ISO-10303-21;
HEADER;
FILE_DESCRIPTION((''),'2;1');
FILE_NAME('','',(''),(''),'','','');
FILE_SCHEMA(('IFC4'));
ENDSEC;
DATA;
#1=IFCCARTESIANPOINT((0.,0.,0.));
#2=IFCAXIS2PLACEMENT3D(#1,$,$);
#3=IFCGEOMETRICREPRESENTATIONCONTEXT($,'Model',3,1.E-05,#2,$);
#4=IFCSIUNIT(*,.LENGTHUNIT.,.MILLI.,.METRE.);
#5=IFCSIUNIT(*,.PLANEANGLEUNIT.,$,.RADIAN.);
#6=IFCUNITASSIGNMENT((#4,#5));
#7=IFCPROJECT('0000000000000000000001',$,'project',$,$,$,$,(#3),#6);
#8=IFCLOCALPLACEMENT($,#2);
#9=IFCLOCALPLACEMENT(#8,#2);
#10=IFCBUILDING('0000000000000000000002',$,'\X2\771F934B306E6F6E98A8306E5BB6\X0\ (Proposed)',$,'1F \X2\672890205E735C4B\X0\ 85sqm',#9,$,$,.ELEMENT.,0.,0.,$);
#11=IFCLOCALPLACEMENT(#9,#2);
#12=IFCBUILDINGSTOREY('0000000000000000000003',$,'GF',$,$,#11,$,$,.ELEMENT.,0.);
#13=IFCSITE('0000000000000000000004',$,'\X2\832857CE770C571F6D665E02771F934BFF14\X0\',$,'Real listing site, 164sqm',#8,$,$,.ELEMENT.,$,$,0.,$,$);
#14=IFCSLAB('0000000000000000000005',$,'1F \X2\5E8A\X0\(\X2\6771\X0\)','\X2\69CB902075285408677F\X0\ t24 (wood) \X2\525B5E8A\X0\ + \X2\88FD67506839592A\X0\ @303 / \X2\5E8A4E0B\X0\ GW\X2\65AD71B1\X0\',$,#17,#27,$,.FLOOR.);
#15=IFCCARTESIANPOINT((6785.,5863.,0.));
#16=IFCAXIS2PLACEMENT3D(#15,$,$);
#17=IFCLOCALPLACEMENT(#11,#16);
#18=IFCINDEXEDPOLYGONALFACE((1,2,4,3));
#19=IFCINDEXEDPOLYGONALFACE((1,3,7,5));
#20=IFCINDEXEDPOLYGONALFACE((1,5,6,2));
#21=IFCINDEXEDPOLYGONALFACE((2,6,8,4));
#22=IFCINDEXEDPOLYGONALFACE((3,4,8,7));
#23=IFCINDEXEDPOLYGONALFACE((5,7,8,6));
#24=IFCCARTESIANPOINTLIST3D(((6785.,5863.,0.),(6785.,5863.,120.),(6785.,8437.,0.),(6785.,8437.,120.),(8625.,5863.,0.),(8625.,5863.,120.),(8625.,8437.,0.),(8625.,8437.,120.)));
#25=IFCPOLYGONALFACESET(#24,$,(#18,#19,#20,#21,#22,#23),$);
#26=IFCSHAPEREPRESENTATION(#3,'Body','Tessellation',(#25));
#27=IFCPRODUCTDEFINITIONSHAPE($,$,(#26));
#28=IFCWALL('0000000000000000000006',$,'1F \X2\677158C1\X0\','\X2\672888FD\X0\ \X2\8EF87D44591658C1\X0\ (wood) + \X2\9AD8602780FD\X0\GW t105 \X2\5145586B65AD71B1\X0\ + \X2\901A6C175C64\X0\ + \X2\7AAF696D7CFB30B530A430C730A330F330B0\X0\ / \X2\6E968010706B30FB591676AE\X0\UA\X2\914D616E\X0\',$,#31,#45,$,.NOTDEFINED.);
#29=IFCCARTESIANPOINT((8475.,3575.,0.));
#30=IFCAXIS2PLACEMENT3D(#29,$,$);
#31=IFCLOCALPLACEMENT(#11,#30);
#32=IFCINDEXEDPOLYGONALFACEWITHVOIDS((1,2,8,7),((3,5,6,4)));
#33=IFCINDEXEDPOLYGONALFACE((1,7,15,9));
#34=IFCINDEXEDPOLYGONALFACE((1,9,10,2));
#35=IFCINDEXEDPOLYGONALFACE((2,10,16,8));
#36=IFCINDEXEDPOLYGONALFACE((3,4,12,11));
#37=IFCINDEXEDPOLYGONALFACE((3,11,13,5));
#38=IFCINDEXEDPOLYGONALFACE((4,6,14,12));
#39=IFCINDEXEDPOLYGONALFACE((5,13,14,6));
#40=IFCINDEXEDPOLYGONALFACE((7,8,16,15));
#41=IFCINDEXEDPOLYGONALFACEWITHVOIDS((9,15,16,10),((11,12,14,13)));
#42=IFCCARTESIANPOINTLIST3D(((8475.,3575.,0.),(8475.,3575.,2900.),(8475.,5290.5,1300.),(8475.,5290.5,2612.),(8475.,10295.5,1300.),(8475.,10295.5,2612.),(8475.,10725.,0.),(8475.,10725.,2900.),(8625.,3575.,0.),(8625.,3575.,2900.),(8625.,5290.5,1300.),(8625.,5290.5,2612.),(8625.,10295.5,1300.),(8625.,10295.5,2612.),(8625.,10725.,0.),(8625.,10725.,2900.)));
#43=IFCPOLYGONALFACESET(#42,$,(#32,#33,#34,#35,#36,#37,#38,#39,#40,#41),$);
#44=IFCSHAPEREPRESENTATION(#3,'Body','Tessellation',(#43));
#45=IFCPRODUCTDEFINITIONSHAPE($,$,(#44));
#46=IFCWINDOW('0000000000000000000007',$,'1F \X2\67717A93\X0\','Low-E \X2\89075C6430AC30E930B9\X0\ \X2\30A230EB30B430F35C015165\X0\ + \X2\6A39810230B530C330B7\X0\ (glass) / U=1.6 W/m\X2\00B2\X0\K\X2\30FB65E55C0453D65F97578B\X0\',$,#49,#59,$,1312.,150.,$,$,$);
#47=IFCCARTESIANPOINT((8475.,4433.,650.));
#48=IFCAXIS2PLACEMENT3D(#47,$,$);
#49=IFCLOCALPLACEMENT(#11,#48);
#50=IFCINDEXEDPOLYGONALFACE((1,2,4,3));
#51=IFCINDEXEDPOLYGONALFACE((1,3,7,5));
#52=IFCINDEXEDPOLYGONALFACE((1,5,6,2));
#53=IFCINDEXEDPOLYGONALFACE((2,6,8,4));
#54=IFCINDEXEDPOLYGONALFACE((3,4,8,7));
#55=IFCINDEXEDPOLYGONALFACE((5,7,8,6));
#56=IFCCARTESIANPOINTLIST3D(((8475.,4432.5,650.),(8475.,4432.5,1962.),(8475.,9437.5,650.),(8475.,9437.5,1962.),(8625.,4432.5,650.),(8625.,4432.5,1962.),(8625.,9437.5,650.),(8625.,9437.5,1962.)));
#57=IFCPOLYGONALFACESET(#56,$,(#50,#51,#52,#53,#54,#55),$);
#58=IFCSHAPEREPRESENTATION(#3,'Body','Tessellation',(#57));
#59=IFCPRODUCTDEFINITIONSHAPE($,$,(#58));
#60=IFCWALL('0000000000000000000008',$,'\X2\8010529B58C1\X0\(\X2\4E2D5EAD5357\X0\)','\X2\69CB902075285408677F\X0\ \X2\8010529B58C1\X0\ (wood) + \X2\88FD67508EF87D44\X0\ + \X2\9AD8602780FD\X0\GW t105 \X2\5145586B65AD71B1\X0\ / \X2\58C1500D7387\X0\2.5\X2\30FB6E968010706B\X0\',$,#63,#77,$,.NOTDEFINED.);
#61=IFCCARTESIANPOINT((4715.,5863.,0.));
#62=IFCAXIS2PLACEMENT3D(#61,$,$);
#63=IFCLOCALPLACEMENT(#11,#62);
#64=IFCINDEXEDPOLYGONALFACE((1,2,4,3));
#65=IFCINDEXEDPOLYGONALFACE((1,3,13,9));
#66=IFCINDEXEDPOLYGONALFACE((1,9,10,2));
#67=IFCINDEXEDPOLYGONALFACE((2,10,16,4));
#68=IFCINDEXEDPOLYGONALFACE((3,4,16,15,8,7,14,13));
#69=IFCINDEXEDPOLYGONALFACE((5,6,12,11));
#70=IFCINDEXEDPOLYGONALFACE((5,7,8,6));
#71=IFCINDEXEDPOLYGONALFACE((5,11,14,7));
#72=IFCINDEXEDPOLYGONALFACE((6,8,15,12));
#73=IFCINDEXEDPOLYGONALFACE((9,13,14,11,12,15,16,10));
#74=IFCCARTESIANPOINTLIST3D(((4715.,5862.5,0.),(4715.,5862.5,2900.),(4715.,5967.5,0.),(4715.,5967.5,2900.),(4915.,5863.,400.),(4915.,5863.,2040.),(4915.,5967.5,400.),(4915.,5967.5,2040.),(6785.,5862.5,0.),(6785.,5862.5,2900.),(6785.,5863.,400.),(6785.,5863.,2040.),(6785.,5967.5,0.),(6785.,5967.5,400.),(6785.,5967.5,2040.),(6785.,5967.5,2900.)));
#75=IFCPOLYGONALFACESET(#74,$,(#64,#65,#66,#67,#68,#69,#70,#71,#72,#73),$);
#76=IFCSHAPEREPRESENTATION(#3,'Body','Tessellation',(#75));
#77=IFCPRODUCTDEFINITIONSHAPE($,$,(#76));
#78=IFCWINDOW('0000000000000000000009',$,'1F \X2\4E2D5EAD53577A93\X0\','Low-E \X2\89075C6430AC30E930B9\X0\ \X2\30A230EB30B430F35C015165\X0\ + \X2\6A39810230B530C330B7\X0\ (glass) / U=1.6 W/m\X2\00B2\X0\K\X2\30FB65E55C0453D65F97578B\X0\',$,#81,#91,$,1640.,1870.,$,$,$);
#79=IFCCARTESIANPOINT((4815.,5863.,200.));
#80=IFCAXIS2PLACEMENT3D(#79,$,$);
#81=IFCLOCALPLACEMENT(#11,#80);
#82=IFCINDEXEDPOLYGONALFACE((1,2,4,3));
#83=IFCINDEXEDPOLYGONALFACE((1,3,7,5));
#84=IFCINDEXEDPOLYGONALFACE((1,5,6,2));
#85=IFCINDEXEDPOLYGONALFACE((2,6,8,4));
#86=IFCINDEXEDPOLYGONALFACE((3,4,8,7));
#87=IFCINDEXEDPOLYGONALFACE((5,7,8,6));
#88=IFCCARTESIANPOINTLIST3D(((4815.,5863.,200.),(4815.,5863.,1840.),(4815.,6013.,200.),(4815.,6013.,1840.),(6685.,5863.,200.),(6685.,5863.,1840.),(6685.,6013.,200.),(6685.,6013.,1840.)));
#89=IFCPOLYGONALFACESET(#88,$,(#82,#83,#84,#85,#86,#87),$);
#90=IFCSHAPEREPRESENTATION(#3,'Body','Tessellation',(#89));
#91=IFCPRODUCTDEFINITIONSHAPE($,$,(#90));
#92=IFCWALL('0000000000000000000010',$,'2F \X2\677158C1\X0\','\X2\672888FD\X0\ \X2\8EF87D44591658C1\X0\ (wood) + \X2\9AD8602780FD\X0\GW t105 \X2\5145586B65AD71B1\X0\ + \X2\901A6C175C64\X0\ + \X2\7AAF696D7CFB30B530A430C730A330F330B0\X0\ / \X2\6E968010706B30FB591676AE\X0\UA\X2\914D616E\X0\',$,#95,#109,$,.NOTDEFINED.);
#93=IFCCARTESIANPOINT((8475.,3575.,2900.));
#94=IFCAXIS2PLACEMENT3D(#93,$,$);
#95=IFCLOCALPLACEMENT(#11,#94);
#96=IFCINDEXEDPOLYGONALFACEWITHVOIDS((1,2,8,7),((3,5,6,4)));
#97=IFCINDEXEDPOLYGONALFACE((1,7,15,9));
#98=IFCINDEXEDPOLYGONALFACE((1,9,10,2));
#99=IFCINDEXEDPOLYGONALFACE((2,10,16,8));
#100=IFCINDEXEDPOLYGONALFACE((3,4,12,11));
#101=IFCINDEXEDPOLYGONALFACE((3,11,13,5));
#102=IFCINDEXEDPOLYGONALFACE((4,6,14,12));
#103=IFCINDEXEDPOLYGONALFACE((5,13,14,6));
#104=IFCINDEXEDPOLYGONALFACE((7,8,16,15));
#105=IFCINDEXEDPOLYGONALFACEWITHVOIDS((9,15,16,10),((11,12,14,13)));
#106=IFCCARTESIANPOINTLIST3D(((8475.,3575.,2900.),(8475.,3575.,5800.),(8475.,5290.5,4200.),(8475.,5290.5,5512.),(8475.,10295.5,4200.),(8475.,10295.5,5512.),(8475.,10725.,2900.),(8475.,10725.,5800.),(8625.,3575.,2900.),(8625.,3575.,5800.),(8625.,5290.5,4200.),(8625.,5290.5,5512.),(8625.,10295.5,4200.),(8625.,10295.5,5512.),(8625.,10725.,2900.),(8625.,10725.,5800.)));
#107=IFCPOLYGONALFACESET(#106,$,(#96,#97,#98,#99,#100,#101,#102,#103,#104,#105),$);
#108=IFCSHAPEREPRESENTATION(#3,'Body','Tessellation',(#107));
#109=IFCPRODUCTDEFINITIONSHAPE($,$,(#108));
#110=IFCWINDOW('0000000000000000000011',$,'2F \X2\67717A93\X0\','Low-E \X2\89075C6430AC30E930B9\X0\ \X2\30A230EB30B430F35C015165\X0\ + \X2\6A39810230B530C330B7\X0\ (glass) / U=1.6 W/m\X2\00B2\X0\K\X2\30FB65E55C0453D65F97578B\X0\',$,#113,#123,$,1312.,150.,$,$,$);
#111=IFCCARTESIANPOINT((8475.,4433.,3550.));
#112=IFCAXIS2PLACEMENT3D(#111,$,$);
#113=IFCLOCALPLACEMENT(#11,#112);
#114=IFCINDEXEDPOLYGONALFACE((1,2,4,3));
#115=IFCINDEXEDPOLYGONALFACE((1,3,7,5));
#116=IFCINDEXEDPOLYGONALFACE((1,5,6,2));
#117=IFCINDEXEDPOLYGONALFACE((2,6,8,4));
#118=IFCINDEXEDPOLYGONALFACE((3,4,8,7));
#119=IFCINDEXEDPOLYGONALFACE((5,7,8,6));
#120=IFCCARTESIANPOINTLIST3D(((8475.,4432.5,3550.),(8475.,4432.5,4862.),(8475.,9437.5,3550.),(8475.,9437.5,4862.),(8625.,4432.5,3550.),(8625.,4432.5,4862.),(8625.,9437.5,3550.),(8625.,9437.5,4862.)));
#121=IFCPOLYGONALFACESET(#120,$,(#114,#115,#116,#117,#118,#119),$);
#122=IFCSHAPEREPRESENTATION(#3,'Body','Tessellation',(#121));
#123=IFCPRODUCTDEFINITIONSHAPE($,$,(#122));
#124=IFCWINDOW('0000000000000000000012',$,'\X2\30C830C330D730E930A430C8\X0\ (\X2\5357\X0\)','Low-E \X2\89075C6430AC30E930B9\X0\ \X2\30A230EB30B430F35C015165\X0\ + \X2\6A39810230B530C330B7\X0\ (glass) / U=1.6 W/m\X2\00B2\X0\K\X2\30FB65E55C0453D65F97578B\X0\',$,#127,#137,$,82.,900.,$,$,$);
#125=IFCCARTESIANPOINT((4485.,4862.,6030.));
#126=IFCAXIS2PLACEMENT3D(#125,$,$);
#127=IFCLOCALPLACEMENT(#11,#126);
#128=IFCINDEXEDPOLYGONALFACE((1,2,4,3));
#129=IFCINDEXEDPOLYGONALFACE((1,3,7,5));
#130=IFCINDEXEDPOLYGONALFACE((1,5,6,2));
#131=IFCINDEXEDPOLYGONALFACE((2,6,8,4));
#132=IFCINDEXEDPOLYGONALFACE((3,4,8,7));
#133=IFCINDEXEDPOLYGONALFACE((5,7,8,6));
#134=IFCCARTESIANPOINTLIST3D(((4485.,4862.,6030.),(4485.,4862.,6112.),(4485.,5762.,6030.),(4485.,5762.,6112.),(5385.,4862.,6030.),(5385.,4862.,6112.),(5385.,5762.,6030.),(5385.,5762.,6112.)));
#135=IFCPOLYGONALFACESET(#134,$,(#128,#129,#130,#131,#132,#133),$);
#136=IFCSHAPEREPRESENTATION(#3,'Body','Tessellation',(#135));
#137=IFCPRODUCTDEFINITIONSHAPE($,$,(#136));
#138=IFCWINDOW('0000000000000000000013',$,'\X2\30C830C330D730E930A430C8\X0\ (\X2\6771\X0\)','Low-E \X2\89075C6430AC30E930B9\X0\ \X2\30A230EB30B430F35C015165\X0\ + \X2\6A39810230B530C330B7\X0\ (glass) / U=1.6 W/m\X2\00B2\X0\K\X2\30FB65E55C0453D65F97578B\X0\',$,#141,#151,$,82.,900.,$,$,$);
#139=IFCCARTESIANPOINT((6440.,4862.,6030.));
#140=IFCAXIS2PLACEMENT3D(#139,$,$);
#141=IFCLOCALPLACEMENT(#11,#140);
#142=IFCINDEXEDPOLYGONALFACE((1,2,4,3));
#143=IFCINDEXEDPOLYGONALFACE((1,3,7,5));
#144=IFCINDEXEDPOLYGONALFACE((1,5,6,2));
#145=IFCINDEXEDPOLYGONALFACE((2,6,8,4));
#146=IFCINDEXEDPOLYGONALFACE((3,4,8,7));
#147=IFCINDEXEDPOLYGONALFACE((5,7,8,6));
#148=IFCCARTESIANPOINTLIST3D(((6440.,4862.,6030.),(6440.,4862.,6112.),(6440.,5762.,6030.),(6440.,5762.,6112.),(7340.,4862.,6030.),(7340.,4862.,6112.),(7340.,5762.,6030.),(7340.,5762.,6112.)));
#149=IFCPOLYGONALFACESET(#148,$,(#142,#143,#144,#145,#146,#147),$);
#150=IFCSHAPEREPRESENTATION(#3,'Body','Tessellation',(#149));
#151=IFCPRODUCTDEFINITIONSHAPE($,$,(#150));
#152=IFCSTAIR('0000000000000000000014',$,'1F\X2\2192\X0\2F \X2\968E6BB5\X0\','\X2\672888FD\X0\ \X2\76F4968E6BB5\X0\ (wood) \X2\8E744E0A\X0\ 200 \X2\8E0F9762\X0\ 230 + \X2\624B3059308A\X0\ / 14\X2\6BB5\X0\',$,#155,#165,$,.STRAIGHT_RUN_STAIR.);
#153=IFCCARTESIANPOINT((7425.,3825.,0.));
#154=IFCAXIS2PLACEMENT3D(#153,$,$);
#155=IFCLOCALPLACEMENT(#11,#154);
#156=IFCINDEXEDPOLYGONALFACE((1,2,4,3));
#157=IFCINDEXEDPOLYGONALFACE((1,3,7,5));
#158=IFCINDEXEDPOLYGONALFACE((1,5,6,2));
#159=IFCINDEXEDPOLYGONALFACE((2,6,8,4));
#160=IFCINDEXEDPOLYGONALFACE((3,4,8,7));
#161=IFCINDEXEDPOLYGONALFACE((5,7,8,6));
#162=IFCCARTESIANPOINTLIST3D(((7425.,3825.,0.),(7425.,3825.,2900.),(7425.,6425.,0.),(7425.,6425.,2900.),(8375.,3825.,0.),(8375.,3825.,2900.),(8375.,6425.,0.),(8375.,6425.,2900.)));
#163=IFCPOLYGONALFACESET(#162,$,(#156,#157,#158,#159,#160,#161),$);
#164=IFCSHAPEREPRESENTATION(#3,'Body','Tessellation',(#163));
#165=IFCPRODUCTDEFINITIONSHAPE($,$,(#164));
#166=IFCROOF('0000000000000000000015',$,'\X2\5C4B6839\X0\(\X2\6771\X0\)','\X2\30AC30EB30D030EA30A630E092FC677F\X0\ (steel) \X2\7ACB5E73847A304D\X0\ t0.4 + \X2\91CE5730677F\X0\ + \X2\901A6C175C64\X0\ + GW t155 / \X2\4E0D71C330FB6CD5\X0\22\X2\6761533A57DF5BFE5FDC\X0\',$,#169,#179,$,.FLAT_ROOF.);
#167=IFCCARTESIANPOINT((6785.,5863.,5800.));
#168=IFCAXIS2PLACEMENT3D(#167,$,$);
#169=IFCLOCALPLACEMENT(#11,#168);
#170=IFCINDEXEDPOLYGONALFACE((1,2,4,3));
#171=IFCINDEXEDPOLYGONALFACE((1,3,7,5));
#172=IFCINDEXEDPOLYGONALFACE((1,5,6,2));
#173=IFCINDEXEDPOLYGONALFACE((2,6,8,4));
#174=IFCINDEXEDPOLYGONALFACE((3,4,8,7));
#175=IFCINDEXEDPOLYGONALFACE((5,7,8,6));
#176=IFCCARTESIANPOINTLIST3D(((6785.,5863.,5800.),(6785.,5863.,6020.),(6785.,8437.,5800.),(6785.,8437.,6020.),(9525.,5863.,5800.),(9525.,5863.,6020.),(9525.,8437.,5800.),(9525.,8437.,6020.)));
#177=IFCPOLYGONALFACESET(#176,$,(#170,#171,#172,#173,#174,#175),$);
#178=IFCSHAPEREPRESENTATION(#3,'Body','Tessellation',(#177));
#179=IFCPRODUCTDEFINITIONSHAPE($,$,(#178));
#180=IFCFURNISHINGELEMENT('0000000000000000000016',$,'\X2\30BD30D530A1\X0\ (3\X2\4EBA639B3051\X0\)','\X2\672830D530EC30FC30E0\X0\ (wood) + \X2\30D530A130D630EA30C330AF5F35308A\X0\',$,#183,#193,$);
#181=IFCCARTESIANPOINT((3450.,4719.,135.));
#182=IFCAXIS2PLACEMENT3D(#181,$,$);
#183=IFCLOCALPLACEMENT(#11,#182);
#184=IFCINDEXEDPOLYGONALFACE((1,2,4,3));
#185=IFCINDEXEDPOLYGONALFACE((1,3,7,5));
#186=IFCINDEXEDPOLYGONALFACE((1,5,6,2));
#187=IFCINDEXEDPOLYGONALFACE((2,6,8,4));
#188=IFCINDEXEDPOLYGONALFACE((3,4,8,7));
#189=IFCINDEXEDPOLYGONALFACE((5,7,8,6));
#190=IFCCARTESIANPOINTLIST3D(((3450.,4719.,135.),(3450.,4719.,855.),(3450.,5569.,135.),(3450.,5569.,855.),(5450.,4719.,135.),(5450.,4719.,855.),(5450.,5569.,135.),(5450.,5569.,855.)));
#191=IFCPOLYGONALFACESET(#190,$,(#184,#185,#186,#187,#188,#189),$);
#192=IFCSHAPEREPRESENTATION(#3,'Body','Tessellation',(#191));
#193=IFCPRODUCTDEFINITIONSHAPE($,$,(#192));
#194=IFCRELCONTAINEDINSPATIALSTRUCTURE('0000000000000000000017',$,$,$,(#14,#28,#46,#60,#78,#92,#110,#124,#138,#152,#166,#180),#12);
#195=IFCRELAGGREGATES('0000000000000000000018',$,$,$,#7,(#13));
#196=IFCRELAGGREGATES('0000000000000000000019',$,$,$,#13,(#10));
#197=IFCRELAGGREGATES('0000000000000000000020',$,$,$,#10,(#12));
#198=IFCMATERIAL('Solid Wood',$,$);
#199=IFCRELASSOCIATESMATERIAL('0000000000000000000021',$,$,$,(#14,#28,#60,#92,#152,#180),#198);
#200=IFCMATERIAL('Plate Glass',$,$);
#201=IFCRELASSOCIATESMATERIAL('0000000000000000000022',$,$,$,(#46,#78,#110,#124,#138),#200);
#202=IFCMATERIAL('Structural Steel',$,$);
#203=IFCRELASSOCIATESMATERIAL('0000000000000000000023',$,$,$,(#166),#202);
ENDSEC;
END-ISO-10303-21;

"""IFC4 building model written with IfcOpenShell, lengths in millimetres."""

from ifc_helpers import new_model, si_unit, frame, frame_2d, origin, place, context, project, spatial, rectangle, extrude, material, element, fill, save


model = new_model("IFC4")

# Units and contexts
model_context = context("Model", 3, precision=1e-05, world=origin())
ifc_project = project(units=[si_unit("LENGTHUNIT", "METRE", prefix="MILLI"), si_unit("PLANEANGLEUNIT", "RADIAN")], contexts=[model_context])

# Site, building, storey
site_placement = place(None, origin())
site = spatial("IfcSite", under=ifc_project, at=site_placement, Name="茨城県土浦市真鍋４", ObjectType="Real listing site, 164sqm", CompositionType="ELEMENT", RefElevation=0.0)
building_placement = place(site_placement, origin())
building = spatial("IfcBuilding", under=site, at=building_placement, Name="真鍋の潮風の家 (Proposed)", ObjectType="1F 木造平屋 85sqm", CompositionType="ELEMENT", ElevationOfRefHeight=0.0, ElevationOfTerrain=0.0)
storey_placement = place(building_placement, origin())
storey = spatial("IfcBuildingStorey", under=building, at=storey_placement, Name="GF", CompositionType="ELEMENT", Elevation=0.0)

# Slab
ifc_material_1 = material(Name="Solid Wood")
slab_placement = place(storey_placement, frame((6785.0, 5863.0, 0.0)))
element("IfcSlab", 1, at=slab_placement, inside=storey, material=ifc_material_1, Name="1F 床(東)", Description="構造用合板 t24 (wood) 剛床 + 製材根太 @303 / 床下 GW断熱", PredefinedType="FLOOR", context=model_context, shape_type="SweptSolid", body=[
    extrude(rectangle(XDim=1840.0, YDim=2574.0, at=frame_2d((920.0, 1287.0))), frame((6785.0, 5863.0, 0.0)), (0.0, 0.0, 1.0), 120.0),
])

# Walls, openings, windows
wall_1_placement = place(storey_placement, frame((8475.0, 3575.0, 0.0)))
wall_1 = element("IfcWall", 2, at=wall_1_placement, inside=storey, material=ifc_material_1, Name="1F 東壁", Description="木製 軸組外壁 (wood) + 高性能GW t105 充填断熱 + 通気層 + 窯業系サイディング / 準耐火・外皮UA配慮", PredefinedType="NOTDEFINED", context=model_context, shape_type="SweptSolid", body=[
    extrude(rectangle(XDim=150.0, YDim=7150.0, at=frame_2d((75.0, 3575.0))), frame((8475.0, 3575.0, 0.0)), (0.0, 0.0, 1.0), 2900.0),
])
opening_1_placement = place(storey_placement, frame((8475.0, 4433.0, 650.0)))
opening_1 = element("IfcOpeningElement", 3, at=opening_1_placement, cuts=wall_1, PredefinedType="NOTDEFINED", context=model_context, shape_type="SweptSolid", body=[
    extrude(rectangle(XDim=150.0, YDim=5005.0, at=frame_2d((75.0, 2502.0))), frame((8475.0, 4433.0, 650.0)), (0.0, 0.0, 1.0), 1312.0),
])
ifc_material_2 = material(Name="Plate Glass")
window_1_placement = place(storey_placement, frame((8475.0, 4433.0, 650.0)))
window_1 = element("IfcWindow", 4, at=window_1_placement, inside=storey, material=ifc_material_2, Name="1F 東窓", Description="Low-E 複層ガラス アルゴン封入 + 樹脂サッシ (glass) / U=1.6 W/m²K・日射取得型", OverallHeight=1312.0, OverallWidth=150.0, context=model_context, shape_type="SweptSolid", body=[
    extrude(rectangle(XDim=150.0, YDim=5005.0, at=frame_2d((75.0, 2502.0))), frame((8475.0, 4433.0, 650.0)), (0.0, 0.0, 1.0), 1312.0),
])
fill(opening_1, window_1)
wall_2_placement = place(storey_placement, frame((4715.0, 5863.0, 0.0)))
wall_2 = element("IfcWall", 5, at=wall_2_placement, inside=storey, material=ifc_material_1, Name="耐力壁(中庭南)", Description="構造用合板 耐力壁 (wood) + 製材軸組 + 高性能GW t105 充填断熱 / 壁倍率2.5・準耐火", PredefinedType="NOTDEFINED", context=model_context, shape_type="SweptSolid", body=[
    extrude(rectangle(XDim=2070.0, YDim=105.0, at=frame_2d((1035.0, 52.0))), frame((4715.0, 5863.0, 0.0)), (0.0, 0.0, 1.0), 2900.0),
])
opening_2_placement = place(storey_placement, frame((4815.0, 5863.0, 200.0)))
opening_2 = element("IfcOpeningElement", 6, at=opening_2_placement, cuts=wall_2, PredefinedType="NOTDEFINED", context=model_context, shape_type="SweptSolid", body=[
    extrude(rectangle(XDim=1870.0, YDim=150.0, at=frame_2d((935.0, 75.0))), frame((4815.0, 5863.0, 200.0)), (0.0, 0.0, 1.0), 1640.0),
])
window_2_placement = place(storey_placement, frame((4815.0, 5863.0, 200.0)))
window_2 = element("IfcWindow", 7, at=window_2_placement, inside=storey, material=ifc_material_2, Name="1F 中庭南窓", Description="Low-E 複層ガラス アルゴン封入 + 樹脂サッシ (glass) / U=1.6 W/m²K・日射取得型", OverallHeight=1640.0, OverallWidth=1870.0, context=model_context, shape_type="SweptSolid", body=[
    extrude(rectangle(XDim=1870.0, YDim=150.0, at=frame_2d((935.0, 75.0))), frame((4815.0, 5863.0, 200.0)), (0.0, 0.0, 1.0), 1640.0),
])
fill(opening_2, window_2)

# Wall, opening, window
wall_3_placement = place(storey_placement, frame((8475.0, 3575.0, 2900.0)))
wall_3 = element("IfcWall", 8, at=wall_3_placement, inside=storey, material=ifc_material_1, Name="2F 東壁", Description="木製 軸組外壁 (wood) + 高性能GW t105 充填断熱 + 通気層 + 窯業系サイディング / 準耐火・外皮UA配慮", PredefinedType="NOTDEFINED", context=model_context, shape_type="SweptSolid", body=[
    extrude(rectangle(XDim=150.0, YDim=7150.0, at=frame_2d((75.0, 3575.0))), frame((8475.0, 3575.0, 2900.0)), (0.0, 0.0, 1.0), 2900.0),
])
opening_3_placement = place(storey_placement, frame((8475.0, 4433.0, 3550.0)))
opening_3 = element("IfcOpeningElement", 9, at=opening_3_placement, cuts=wall_3, PredefinedType="NOTDEFINED", context=model_context, shape_type="SweptSolid", body=[
    extrude(rectangle(XDim=150.0, YDim=5005.0, at=frame_2d((75.0, 2502.0))), frame((8475.0, 4433.0, 3550.0)), (0.0, 0.0, 1.0), 1312.0),
])
window_3_placement = place(storey_placement, frame((8475.0, 4433.0, 3550.0)))
window_3 = element("IfcWindow", 10, at=window_3_placement, inside=storey, material=ifc_material_2, Name="2F 東窓", Description="Low-E 複層ガラス アルゴン封入 + 樹脂サッシ (glass) / U=1.6 W/m²K・日射取得型", OverallHeight=1312.0, OverallWidth=150.0, context=model_context, shape_type="SweptSolid", body=[
    extrude(rectangle(XDim=150.0, YDim=5005.0, at=frame_2d((75.0, 2502.0))), frame((8475.0, 4433.0, 3550.0)), (0.0, 0.0, 1.0), 1312.0),
])
fill(opening_3, window_3)

# Windows
window_4_placement = place(storey_placement, frame((4485.0, 4862.0, 6030.0)))
element("IfcWindow", 11, at=window_4_placement, inside=storey, material=ifc_material_2, Name="トップライト (南)", Description="Low-E 複層ガラス アルゴン封入 + 樹脂サッシ (glass) / U=1.6 W/m²K・日射取得型", OverallHeight=82.0, OverallWidth=900.0, context=model_context, shape_type="SweptSolid", body=[
    extrude(rectangle(XDim=900.0, YDim=900.0, at=frame_2d((450.0, 450.0))), frame((4485.0, 4862.0, 6030.0)), (0.0, 0.0, 1.0), 82.0),
])
window_5_placement = place(storey_placement, frame((6440.0, 4862.0, 6030.0)))
element("IfcWindow", 12, at=window_5_placement, inside=storey, material=ifc_material_2, Name="トップライト (東)", Description="Low-E 複層ガラス アルゴン封入 + 樹脂サッシ (glass) / U=1.6 W/m²K・日射取得型", OverallHeight=82.0, OverallWidth=900.0, context=model_context, shape_type="SweptSolid", body=[
    extrude(rectangle(XDim=900.0, YDim=900.0, at=frame_2d((450.0, 450.0))), frame((6440.0, 4862.0, 6030.0)), (0.0, 0.0, 1.0), 82.0),
])

# Stair
stair_placement = place(storey_placement, frame((7425.0, 3825.0, 0.0)))
element("IfcStair", 13, at=stair_placement, inside=storey, material=ifc_material_1, Name="1F→2F 階段", Description="木製 直階段 (wood) 蹴上 200 踏面 230 + 手すり / 14段", PredefinedType="STRAIGHT_RUN_STAIR", context=model_context, shape_type="SweptSolid", body=[
    extrude(rectangle(XDim=950.0, YDim=2600.0, at=frame_2d((475.0, 1300.0))), frame((7425.0, 3825.0, 0.0)), (0.0, 0.0, 1.0), 2900.0),
])

# Roof
ifc_material_3 = material(Name="Structural Steel")
roof_placement = place(storey_placement, frame((6785.0, 5863.0, 5800.0)))
element("IfcRoof", 14, at=roof_placement, inside=storey, material=ifc_material_3, Name="屋根(東)", Description="ガルバリウム鋼板 (steel) 立平葺き t0.4 + 野地板 + 通気層 + GW t155 / 不燃・法22条区域対応", PredefinedType="FLAT_ROOF", context=model_context, shape_type="SweptSolid", body=[
    extrude(rectangle(XDim=2740.0, YDim=2574.0, at=frame_2d((1370.0, 1287.0))), frame((6785.0, 5863.0, 5800.0)), (0.0, 0.0, 1.0), 220.0),
])

# Furnishing element
furnishing_1_placement = place(storey_placement, frame((3450.0, 4719.0, 135.0)))
element("IfcFurnishingElement", 15, at=furnishing_1_placement, inside=storey, material=ifc_material_1, Name="ソファ (3人掛け)", Description="木フレーム (wood) + ファブリック張り", context=model_context, shape_type="SweptSolid", body=[
    extrude(rectangle(XDim=2000.0, YDim=850.0, at=frame_2d((1000.0, 425.0))), frame((3450.0, 4719.0, 135.0)), (0.0, 0.0, 1.0), 720.0),
])

save(model, "model.ifc")
